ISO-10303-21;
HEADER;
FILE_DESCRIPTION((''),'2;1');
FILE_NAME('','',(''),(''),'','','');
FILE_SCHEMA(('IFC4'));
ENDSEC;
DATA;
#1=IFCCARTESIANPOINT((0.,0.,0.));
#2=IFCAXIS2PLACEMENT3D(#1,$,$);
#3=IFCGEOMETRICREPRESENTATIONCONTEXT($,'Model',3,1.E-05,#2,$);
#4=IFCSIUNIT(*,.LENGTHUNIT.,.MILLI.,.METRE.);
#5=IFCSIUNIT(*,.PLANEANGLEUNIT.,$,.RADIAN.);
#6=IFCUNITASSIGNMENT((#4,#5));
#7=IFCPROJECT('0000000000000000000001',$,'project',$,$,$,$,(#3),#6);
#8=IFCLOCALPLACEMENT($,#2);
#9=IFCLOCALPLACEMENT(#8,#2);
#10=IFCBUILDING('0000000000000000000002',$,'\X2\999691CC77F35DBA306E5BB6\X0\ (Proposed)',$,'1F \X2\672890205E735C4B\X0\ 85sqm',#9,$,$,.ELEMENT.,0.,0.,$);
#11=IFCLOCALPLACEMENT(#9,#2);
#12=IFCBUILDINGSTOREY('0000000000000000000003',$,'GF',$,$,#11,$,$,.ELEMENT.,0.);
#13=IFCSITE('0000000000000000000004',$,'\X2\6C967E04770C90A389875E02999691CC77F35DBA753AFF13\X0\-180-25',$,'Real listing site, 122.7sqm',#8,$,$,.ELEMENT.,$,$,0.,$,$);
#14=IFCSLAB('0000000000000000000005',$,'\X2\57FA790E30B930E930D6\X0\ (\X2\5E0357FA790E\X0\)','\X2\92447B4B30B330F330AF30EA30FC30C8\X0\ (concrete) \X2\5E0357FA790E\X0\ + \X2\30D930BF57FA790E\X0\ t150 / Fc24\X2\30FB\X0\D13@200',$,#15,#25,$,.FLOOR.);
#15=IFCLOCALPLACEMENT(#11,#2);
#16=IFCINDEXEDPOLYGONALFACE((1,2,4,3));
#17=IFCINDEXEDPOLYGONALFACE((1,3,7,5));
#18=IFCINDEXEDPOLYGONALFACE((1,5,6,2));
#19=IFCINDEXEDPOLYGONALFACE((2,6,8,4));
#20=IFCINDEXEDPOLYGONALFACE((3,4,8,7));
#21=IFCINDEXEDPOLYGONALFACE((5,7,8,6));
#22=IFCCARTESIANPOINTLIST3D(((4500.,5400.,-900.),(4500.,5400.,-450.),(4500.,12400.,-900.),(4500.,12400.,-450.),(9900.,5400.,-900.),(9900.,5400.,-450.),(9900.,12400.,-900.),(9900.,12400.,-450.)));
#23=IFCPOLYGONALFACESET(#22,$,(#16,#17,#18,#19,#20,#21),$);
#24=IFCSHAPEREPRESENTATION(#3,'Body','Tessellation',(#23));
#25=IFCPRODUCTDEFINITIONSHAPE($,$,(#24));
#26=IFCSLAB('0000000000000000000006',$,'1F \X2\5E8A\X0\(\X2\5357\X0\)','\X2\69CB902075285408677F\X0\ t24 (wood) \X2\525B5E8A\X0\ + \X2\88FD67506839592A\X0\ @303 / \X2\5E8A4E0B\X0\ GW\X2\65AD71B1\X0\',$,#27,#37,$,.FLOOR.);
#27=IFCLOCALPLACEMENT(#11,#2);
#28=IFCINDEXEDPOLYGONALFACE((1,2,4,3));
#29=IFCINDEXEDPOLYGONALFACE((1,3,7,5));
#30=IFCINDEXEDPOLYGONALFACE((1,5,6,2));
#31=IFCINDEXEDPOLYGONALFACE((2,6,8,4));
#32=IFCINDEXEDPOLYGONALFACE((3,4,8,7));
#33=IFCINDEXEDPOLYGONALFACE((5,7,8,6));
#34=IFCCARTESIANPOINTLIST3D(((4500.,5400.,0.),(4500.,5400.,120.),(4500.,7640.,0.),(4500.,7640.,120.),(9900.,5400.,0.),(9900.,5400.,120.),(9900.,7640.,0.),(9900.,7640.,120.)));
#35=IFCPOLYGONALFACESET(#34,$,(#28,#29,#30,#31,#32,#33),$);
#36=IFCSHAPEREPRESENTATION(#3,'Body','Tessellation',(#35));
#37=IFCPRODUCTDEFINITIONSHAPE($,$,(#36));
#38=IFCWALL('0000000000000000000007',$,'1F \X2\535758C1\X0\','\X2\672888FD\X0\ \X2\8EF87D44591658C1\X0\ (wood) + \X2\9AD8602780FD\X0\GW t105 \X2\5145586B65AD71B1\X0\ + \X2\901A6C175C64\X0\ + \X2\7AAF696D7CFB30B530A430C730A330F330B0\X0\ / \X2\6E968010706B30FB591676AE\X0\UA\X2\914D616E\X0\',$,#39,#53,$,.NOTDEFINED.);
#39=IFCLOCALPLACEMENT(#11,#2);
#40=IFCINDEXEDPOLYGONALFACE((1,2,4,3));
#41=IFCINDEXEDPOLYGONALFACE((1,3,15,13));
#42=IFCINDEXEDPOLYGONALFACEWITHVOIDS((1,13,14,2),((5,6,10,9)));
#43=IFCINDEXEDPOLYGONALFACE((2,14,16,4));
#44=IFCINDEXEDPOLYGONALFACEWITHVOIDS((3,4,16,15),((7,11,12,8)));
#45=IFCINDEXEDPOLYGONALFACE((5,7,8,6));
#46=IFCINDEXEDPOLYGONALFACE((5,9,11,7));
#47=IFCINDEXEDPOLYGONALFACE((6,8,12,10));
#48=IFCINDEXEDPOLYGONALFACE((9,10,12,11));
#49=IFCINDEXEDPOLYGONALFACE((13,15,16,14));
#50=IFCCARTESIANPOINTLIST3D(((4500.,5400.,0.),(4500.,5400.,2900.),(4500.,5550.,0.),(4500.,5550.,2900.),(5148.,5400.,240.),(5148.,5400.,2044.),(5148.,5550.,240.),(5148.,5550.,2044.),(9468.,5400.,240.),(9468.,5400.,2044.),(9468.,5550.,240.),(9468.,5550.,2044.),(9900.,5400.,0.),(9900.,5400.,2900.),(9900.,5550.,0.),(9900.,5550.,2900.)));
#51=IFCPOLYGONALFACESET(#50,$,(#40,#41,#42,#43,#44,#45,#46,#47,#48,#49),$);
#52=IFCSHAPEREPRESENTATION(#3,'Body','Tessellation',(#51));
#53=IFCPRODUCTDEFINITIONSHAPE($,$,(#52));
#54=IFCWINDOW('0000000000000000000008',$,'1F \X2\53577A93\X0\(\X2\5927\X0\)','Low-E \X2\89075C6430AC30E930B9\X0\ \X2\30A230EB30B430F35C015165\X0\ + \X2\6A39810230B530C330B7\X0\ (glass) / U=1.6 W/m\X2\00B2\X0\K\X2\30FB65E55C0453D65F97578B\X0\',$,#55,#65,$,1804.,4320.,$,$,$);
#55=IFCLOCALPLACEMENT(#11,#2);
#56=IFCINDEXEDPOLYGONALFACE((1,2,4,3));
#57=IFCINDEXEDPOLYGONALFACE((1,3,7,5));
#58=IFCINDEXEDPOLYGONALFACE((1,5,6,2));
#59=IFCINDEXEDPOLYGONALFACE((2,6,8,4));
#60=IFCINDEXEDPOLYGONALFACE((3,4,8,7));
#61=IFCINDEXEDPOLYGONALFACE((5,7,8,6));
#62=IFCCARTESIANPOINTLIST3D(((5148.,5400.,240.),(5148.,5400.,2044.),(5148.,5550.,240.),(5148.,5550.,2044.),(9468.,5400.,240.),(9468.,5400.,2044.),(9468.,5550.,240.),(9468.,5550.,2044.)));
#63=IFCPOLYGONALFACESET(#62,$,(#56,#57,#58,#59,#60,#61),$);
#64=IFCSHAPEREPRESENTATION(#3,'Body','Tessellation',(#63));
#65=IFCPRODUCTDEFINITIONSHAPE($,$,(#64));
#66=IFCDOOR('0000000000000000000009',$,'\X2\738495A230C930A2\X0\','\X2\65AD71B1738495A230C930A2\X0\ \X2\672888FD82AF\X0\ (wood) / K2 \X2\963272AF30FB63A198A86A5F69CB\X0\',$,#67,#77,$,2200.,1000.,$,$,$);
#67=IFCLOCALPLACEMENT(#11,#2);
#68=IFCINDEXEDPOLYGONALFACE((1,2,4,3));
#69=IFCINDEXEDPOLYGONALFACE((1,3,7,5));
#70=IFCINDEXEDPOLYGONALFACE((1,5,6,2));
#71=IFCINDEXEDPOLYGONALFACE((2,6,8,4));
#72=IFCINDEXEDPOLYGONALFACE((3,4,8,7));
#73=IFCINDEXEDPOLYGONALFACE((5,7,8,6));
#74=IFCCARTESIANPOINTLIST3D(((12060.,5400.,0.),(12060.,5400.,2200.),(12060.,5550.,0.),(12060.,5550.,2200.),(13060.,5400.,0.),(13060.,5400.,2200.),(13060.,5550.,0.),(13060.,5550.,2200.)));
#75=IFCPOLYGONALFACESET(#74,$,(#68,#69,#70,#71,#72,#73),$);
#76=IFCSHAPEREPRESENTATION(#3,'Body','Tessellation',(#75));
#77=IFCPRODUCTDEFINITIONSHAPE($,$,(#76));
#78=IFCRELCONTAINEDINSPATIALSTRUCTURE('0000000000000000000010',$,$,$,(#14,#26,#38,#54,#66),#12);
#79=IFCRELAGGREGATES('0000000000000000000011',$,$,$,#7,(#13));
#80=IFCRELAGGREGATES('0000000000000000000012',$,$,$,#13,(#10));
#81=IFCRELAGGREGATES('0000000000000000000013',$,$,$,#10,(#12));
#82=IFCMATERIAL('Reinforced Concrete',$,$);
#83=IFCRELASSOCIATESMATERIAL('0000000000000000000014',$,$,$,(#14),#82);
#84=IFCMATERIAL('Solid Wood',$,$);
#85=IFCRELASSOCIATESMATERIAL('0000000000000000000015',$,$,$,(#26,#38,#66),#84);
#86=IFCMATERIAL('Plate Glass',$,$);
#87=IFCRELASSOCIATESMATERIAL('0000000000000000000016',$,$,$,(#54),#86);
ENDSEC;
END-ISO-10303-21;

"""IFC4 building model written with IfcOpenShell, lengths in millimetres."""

from ifc_helpers import new_model, si_unit, frame, frame_2d, origin, place, context, project, spatial, rectangle, extrude, material, element, fill, save


model = new_model("IFC4")

# Units and contexts
model_context = context("Model", 3, precision=1e-05, world=origin())
ifc_project = project(units=[si_unit("LENGTHUNIT", "METRE", prefix="MILLI"), si_unit("PLANEANGLEUNIT", "RADIAN")], contexts=[model_context])

# Site, building, storey
site_placement = place(None, origin())
site = spatial("IfcSite", under=ifc_project, at=site_placement, Name="沖縄県那覇市首里石嶺町３-180-25", ObjectType="Real listing site, 122.7sqm", CompositionType="ELEMENT", RefElevation=0.0)
building_placement = place(site_placement, origin())
building = spatial("IfcBuilding", under=site, at=building_placement, Name="首里石嶺の家 (Proposed)", ObjectType="1F 木造平屋 85sqm", CompositionType="ELEMENT", ElevationOfRefHeight=0.0, ElevationOfTerrain=0.0)
storey_placement = place(building_placement, origin())
storey = spatial("IfcBuildingStorey", under=building, at=storey_placement, Name="GF", CompositionType="ELEMENT", Elevation=0.0)

# Slabs
ifc_material_1 = material(Name="Reinforced Concrete")
slab_1_placement = place(storey_placement, frame((2250.0, 2700.0, -450.0)))
element("IfcSlab", 1, at=slab_1_placement, inside=storey, material=ifc_material_1, Name="基礎スラブ (布基礎)", Description="鉄筋コンクリート (concrete) 布基礎 + ベタ基礎 t150 / Fc24・D13@200", PredefinedType="FLOOR", context=model_context, shape_type="SweptSolid", body=[
    extrude(rectangle(XDim=5400.0, YDim=7000.0, at=frame_2d((2700.0, 3500.0))), frame((2250.0, 2700.0, -450.0)), (0.0, 0.0, 1.0), 450.0),
])
ifc_material_2 = material(Name="Solid Wood")
slab_2_placement = place(storey_placement, frame((2250.0, 2700.0, 0.0)))
element("IfcSlab", 2, at=slab_2_placement, inside=storey, material=ifc_material_2, Name="1F 床(南)", Description="構造用合板 t24 (wood) 剛床 + 製材根太 @303 / 床下 GW断熱", PredefinedType="FLOOR", context=model_context, shape_type="SweptSolid", body=[
    extrude(rectangle(XDim=5400.0, YDim=2240.0, at=frame_2d((2700.0, 1120.0))), frame((2250.0, 2700.0, 0.0)), (0.0, 0.0, 1.0), 120.0),
])

# Wall, openings, window, door
wall_1_placement = place(storey_placement, frame((2250.0, 2700.0, 0.0)))
wall_1 = element("IfcWall", 3, at=wall_1_placement, inside=storey, material=ifc_material_2, Name="1F 南壁", Description="木製 軸組外壁 (wood) + 高性能GW t105 充填断熱 + 通気層 + 窯業系サイディング / 準耐火・外皮UA配慮", PredefinedType="NOTDEFINED", context=model_context, shape_type="SweptSolid", body=[
    extrude(rectangle(XDim=5400.0, YDim=150.0, at=frame_2d((2700.0, 75.0))), frame((2250.0, 2700.0, 0.0)), (0.0, 0.0, 1.0), 2900.0),
])
opening_1_placement = place(storey_placement, frame((2574.0, 2700.0, 120.0)))
opening_1 = element("IfcOpeningElement", 4, at=opening_1_placement, cuts=wall_1, PredefinedType="NOTDEFINED", context=model_context, shape_type="SweptSolid", body=[
    extrude(rectangle(XDim=4320.0, YDim=150.0, at=frame_2d((2160.0, 75.0))), frame((2574.0, 2700.0, 120.0)), (0.0, 0.0, 1.0), 1804.0),
])
opening_2_placement = place(storey_placement, frame((6030.0, 2700.0, 0.0)))
opening_2 = element("IfcOpeningElement", 5, at=opening_2_placement, cuts=wall_1, PredefinedType="NOTDEFINED", context=model_context, shape_type="SweptSolid", body=[
    extrude(rectangle(XDim=1000.0, YDim=150.0, at=frame_2d((500.0, 75.0))), frame((6030.0, 2700.0, 0.0)), (0.0, 0.0, 1.0), 2200.0),
])
ifc_material_3 = material(Name="Plate Glass")
window_1_placement = place(storey_placement, frame((2574.0, 2700.0, 120.0)))
window_1 = element("IfcWindow", 6, at=window_1_placement, inside=storey, material=ifc_material_3, Name="1F 南窓(大)", Description="Low-E 複層ガラス アルゴン封入 + 樹脂サッシ (glass) / U=1.6 W/m²K・日射取得型", OverallHeight=1804.0, OverallWidth=4320.0, context=model_context, shape_type="SweptSolid", body=[
    extrude(rectangle(XDim=4320.0, YDim=150.0, at=frame_2d((2160.0, 75.0))), frame((2574.0, 2700.0, 120.0)), (0.0, 0.0, 1.0), 1804.0),
])
fill(opening_1, window_1)
door_placement = place(storey_placement, frame((6030.0, 2700.0, 0.0)))
door = element("IfcDoor", 7, at=door_placement, inside=storey, material=ifc_material_2, Name="玄関ドア", Description="断熱玄関ドア 木製芯 (wood) / K2 防犯・採風機構", OverallHeight=2200.0, OverallWidth=1000.0, context=model_context, shape_type="SweptSolid", body=[
    extrude(rectangle(XDim=1000.0, YDim=150.0, at=frame_2d((500.0, 75.0))), frame((6030.0, 2700.0, 0.0)), (0.0, 0.0, 1.0), 2200.0),
])
fill(opening_2, door)

save(model, "model.ifc")
